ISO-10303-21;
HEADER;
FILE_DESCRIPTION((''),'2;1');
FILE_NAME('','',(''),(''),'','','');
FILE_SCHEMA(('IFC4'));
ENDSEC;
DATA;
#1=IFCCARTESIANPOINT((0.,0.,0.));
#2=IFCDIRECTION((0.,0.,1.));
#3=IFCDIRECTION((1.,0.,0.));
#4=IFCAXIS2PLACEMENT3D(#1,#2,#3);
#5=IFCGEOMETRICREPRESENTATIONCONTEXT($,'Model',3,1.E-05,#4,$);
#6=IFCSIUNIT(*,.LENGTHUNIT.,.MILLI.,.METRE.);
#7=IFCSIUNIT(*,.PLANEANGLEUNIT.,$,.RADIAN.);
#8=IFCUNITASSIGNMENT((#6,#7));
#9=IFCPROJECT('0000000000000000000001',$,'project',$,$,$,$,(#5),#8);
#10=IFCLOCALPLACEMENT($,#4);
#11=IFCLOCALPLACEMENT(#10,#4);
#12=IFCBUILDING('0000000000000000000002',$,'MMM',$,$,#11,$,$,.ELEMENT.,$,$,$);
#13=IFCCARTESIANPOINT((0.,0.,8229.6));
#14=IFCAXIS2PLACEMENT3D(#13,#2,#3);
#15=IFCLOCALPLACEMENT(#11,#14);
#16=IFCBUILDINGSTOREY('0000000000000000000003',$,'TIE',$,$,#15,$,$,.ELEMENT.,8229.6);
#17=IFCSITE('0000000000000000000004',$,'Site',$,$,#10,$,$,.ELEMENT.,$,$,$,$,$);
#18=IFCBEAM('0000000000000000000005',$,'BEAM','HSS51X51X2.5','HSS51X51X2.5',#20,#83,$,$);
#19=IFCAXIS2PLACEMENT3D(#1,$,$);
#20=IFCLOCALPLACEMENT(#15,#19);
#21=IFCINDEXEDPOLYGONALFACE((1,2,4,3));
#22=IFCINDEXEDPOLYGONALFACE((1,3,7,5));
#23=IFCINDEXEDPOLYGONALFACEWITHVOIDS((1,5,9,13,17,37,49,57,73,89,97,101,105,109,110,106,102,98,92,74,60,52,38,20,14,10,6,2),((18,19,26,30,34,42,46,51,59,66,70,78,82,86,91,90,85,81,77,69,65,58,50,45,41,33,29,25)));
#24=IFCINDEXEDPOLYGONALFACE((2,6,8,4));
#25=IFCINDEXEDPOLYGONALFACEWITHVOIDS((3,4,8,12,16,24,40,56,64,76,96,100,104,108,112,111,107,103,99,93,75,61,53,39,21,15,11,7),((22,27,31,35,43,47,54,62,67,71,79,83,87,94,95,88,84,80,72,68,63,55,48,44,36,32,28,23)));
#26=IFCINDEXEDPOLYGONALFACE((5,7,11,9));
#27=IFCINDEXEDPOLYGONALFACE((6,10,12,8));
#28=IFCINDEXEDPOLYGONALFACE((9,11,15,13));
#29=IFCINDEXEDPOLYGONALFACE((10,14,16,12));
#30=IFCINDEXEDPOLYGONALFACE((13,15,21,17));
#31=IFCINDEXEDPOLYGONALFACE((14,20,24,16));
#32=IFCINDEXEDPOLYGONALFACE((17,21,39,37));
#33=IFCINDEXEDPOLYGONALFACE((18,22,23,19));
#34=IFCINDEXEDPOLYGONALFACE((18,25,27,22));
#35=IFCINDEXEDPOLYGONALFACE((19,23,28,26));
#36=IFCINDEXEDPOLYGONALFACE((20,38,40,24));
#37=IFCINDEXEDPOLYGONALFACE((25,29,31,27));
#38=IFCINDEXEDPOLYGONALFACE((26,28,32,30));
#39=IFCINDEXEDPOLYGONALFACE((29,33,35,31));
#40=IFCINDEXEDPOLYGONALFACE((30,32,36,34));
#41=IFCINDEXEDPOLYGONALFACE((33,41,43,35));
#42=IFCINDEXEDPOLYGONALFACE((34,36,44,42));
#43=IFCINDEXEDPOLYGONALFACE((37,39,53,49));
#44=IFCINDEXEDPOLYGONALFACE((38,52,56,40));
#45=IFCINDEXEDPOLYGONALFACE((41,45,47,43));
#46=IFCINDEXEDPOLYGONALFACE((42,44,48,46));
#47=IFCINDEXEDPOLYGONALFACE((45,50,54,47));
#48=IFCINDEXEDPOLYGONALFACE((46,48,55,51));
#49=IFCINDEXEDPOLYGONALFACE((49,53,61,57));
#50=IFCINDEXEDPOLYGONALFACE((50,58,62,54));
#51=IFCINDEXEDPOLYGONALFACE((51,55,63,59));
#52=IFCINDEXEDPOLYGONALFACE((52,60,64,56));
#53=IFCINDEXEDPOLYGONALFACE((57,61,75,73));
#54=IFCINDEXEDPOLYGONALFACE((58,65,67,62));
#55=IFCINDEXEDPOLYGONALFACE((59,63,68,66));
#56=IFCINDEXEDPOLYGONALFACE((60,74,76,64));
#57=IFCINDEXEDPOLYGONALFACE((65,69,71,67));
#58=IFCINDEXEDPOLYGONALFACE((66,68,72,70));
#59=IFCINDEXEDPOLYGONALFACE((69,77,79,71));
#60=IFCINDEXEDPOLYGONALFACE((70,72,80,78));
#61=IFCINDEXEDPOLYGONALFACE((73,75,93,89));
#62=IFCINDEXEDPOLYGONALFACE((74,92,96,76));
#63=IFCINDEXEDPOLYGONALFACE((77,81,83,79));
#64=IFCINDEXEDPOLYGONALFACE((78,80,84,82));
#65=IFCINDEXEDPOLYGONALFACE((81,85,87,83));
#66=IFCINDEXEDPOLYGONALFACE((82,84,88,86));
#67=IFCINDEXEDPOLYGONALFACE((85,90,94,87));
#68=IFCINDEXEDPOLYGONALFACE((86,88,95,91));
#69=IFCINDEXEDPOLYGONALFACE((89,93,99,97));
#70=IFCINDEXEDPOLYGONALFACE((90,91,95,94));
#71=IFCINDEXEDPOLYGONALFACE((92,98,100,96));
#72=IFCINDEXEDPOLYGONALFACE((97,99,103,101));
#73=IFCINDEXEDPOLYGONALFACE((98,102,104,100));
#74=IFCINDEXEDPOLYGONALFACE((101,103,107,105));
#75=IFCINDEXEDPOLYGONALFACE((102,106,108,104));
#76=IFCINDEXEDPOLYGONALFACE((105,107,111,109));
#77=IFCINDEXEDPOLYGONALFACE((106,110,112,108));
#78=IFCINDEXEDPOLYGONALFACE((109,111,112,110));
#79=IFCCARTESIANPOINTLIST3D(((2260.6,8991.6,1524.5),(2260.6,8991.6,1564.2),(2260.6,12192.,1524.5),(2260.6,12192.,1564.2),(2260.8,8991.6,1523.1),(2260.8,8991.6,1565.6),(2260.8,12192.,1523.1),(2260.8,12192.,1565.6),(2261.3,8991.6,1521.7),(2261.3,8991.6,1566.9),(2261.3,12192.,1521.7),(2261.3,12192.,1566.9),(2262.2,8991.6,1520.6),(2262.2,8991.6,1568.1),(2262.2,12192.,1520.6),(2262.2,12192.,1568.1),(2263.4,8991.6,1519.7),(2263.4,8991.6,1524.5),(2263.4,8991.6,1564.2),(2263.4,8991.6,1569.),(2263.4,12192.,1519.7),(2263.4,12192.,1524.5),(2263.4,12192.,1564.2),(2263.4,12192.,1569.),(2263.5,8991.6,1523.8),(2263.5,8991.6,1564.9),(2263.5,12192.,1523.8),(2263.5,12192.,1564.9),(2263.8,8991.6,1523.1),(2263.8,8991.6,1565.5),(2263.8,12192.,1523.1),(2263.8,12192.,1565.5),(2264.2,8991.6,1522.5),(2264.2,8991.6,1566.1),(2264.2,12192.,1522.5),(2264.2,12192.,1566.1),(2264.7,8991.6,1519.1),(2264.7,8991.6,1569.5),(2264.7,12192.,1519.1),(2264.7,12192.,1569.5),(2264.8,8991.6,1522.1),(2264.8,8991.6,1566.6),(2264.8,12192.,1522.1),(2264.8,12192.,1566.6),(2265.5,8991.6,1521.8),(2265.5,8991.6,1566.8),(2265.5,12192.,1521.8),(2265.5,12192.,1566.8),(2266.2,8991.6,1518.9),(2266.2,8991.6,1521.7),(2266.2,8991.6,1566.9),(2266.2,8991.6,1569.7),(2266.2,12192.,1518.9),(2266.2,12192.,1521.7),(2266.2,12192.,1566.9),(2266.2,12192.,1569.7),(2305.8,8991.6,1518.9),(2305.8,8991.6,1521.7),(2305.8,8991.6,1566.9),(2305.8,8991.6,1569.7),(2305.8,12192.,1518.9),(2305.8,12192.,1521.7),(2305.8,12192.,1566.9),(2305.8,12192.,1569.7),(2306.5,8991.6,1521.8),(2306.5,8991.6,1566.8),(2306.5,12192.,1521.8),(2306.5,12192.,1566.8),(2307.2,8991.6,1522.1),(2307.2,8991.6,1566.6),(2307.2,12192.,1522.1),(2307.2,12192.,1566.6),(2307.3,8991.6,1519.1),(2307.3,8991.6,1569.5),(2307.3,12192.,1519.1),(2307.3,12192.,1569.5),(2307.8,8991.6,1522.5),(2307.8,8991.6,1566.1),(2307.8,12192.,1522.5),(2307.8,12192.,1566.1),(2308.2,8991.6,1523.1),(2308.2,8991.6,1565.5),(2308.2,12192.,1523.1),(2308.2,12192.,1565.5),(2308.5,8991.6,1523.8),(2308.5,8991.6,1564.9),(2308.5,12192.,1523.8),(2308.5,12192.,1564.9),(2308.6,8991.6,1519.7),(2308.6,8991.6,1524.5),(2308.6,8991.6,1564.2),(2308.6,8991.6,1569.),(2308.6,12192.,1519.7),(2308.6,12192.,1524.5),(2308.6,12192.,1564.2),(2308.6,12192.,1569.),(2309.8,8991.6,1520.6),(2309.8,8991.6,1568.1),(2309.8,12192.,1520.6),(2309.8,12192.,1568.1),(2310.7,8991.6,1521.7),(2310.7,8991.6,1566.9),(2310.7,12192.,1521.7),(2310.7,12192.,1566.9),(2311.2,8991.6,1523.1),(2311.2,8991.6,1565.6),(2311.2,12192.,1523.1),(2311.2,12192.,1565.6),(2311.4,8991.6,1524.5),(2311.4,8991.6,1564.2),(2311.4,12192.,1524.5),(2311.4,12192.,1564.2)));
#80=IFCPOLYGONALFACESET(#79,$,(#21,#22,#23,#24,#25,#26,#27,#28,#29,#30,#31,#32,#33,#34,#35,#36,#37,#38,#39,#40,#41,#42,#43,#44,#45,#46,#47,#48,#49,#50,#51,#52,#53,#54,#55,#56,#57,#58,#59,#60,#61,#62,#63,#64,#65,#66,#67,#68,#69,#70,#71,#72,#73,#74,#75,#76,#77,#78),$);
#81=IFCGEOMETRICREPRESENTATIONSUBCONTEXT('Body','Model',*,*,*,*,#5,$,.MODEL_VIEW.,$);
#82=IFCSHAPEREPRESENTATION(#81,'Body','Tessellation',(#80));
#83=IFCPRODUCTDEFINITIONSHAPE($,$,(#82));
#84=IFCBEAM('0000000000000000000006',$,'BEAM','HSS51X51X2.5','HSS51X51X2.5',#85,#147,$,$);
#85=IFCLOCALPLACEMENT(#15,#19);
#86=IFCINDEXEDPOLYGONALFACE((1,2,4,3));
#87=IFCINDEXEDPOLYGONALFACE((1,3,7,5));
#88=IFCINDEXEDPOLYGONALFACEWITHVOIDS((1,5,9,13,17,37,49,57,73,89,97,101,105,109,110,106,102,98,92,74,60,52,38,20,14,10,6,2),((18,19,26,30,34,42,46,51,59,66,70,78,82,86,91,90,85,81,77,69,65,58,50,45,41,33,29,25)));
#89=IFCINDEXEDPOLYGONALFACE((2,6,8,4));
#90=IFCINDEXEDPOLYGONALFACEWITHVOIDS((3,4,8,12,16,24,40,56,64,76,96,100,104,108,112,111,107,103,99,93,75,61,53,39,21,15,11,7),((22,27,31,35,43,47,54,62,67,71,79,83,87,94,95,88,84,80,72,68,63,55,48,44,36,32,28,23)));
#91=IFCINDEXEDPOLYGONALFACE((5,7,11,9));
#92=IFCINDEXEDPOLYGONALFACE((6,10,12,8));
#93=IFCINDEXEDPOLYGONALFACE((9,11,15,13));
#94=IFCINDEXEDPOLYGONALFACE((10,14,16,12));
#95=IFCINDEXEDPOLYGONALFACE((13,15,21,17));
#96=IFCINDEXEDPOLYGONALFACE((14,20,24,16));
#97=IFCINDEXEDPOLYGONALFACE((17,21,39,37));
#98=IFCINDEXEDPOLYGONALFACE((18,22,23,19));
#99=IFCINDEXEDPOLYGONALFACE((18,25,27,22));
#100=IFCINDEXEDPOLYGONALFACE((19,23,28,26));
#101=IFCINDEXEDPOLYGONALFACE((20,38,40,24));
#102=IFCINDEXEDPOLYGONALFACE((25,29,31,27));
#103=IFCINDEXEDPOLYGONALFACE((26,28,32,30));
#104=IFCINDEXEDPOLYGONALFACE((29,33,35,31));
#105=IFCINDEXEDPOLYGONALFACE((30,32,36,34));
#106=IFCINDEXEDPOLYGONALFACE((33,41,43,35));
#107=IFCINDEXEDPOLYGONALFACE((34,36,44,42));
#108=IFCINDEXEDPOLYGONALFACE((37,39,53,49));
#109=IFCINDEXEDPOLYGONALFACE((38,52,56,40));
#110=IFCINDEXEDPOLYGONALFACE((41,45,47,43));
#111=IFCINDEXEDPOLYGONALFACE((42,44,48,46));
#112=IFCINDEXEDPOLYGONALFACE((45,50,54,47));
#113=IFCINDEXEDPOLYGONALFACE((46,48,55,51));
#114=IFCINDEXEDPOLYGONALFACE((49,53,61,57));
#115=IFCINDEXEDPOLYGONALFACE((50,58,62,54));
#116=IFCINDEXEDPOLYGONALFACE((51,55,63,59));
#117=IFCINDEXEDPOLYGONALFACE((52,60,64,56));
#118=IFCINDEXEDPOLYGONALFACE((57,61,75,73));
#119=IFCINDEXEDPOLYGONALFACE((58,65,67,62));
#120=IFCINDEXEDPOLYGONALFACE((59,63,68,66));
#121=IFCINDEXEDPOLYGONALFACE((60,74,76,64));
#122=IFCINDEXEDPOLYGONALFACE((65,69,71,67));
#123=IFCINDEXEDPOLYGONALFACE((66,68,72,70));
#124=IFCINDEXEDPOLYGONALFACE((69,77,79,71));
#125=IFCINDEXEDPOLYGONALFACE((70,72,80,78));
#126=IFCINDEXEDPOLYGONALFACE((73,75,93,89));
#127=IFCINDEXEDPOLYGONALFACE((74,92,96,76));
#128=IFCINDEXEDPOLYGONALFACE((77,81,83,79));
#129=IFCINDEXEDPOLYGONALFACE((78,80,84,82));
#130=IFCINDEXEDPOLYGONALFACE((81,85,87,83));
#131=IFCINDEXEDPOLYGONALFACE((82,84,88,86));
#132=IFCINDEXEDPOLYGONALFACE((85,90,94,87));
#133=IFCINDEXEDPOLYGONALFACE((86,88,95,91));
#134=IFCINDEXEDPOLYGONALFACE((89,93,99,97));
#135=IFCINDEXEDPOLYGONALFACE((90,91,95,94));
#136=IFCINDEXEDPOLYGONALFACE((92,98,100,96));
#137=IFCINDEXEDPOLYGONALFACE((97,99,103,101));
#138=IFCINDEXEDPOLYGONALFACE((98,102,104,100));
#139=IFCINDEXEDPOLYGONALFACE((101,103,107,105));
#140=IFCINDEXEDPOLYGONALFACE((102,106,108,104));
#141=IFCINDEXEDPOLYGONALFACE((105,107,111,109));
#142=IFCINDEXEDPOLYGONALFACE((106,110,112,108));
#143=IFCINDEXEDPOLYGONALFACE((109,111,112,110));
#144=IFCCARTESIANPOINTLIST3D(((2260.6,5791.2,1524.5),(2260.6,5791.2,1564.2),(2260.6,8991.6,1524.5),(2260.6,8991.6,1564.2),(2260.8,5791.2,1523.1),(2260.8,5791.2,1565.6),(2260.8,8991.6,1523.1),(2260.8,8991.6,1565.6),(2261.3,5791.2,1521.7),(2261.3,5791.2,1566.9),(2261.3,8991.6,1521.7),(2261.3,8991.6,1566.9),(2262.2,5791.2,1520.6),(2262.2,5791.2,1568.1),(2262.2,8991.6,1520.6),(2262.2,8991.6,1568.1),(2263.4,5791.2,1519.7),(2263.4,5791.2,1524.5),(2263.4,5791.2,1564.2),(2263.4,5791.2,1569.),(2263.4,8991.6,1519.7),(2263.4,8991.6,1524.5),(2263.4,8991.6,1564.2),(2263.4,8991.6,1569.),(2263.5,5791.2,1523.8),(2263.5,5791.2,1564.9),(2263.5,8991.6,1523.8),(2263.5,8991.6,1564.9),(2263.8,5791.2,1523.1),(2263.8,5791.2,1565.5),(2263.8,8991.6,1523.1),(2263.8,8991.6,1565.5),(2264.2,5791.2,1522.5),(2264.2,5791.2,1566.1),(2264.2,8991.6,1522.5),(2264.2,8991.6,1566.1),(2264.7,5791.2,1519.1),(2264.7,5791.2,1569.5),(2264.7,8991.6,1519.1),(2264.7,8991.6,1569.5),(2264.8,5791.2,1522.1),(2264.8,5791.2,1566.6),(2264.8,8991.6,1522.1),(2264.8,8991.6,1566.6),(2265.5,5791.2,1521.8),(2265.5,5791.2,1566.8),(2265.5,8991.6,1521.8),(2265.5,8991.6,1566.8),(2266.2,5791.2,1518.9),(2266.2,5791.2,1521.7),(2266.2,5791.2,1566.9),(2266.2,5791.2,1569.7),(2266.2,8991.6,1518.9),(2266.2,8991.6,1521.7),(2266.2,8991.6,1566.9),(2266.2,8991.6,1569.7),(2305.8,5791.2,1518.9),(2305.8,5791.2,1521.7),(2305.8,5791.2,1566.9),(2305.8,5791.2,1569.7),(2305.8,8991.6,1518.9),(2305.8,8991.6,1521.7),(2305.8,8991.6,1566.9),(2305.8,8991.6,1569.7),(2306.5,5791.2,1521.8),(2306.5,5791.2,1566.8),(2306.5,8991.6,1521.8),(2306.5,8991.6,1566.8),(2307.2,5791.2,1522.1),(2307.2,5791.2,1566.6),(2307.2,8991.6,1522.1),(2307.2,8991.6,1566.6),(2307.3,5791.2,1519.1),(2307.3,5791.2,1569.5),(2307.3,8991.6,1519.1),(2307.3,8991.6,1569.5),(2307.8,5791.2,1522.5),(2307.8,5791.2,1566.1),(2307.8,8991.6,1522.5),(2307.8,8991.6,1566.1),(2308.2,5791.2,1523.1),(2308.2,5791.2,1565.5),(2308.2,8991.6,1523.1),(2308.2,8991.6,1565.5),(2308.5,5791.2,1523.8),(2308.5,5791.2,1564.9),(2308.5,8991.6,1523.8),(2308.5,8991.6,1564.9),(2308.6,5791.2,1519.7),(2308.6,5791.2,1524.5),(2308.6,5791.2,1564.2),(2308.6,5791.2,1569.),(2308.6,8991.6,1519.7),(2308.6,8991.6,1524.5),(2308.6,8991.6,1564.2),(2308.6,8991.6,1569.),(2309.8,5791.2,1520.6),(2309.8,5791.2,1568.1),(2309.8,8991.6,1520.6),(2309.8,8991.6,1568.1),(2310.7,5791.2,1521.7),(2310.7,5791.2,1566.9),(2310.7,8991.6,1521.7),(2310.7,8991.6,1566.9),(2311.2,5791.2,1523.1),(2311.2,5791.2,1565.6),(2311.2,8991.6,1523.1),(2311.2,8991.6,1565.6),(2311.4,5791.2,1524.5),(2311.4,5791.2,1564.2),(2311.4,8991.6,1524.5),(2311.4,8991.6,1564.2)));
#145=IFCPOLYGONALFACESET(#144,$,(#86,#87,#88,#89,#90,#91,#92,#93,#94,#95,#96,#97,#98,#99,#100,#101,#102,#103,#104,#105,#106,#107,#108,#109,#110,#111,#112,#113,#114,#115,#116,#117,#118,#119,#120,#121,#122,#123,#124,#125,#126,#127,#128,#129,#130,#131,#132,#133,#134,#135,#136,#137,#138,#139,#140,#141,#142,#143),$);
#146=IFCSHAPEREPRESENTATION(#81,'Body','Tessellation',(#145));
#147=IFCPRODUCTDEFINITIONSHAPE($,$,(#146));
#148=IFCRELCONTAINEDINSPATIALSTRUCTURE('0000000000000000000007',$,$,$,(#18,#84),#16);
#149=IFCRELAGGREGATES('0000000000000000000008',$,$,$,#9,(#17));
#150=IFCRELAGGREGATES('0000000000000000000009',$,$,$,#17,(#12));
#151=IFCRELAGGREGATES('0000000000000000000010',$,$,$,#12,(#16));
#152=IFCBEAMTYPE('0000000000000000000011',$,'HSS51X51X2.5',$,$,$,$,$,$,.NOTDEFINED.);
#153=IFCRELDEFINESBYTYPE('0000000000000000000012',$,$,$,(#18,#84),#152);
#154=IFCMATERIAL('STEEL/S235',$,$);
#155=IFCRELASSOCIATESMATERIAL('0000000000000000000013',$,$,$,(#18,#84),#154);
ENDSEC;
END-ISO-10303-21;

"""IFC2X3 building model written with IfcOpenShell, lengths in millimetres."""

from ifc_helpers import new_model, si_unit, frame, origin_with_axes, origin_2d_with_axis, place, context, subcontext, project, spatial, hollow_rectangle, extrude, material, type_object, element, save


model = new_model("IFC2X3")

# Units and contexts
model_context = context("Model", 3, precision=1e-05, world=origin_with_axes())
body_context = subcontext(model_context, "Body", "Model", "MODEL_VIEW")
ifc_project = project(units=[si_unit("LENGTHUNIT", "METRE", prefix="MILLI"), si_unit("PLANEANGLEUNIT", "RADIAN")], contexts=[model_context])

# Site, building, storey
site_placement = place(None, origin_with_axes())
site = spatial("IfcSite", under=ifc_project, at=site_placement, Name="Site", CompositionType="ELEMENT")
building_placement = place(site_placement, origin_with_axes())
building = spatial("IfcBuilding", under=site, at=building_placement, Name="MMM", CompositionType="ELEMENT")
storey_placement = place(building_placement, frame((0.0, 0.0, 8229.6), z_axis=(0.0, 0.0, 1.0), x_axis=(1.0, 0.0, 0.0)))
storey = spatial("IfcBuildingStorey", under=building, at=storey_placement, Name="TIE", CompositionType="ELEMENT", Elevation=8229.6)

# Beams
ifc_material = material(Name="STEEL/S235")
beam_type_1 = type_object("IfcBeamType", Name="HSS51X51X2.5", PredefinedType="NOTDEFINED")
for number, where, z_axis, x_axis, name in (
    (1, (2286.0, 8991.6, 1544.3), (0.0, 0.0, 1.0), (0.0, 1.0, 0.0), "BEAM"),
    (2, (2286.0, 5791.2, 1544.3), (0.0, 0.0, 1.0), (0.0, 1.0, 0.0), "BEAM"),
):
    element("IfcBeam", number, at=place(storey_placement, frame(where, z_axis=z_axis, x_axis=x_axis)), inside=storey, type_object=beam_type_1, material=ifc_material, Name=name, Description="HSS51X51X2.5", ObjectType="HSS51X51X2.5", context=body_context, shape_type="SweptSolid", body=[
        extrude(hollow_rectangle(XDim=50.8, YDim=50.8, WallThickness=2.8, InnerFilletRadius=2.8, OuterFilletRadius=5.6, at=origin_2d_with_axis()), frame((3200.4, 0.0, 0.0), z_axis=(-1.0, 0.0, 0.0), x_axis=(0.0, -1.0, 0.0)), (0.0, 0.0, 1.0), 3200.4),
    ])

save(model, "model.ifc")
